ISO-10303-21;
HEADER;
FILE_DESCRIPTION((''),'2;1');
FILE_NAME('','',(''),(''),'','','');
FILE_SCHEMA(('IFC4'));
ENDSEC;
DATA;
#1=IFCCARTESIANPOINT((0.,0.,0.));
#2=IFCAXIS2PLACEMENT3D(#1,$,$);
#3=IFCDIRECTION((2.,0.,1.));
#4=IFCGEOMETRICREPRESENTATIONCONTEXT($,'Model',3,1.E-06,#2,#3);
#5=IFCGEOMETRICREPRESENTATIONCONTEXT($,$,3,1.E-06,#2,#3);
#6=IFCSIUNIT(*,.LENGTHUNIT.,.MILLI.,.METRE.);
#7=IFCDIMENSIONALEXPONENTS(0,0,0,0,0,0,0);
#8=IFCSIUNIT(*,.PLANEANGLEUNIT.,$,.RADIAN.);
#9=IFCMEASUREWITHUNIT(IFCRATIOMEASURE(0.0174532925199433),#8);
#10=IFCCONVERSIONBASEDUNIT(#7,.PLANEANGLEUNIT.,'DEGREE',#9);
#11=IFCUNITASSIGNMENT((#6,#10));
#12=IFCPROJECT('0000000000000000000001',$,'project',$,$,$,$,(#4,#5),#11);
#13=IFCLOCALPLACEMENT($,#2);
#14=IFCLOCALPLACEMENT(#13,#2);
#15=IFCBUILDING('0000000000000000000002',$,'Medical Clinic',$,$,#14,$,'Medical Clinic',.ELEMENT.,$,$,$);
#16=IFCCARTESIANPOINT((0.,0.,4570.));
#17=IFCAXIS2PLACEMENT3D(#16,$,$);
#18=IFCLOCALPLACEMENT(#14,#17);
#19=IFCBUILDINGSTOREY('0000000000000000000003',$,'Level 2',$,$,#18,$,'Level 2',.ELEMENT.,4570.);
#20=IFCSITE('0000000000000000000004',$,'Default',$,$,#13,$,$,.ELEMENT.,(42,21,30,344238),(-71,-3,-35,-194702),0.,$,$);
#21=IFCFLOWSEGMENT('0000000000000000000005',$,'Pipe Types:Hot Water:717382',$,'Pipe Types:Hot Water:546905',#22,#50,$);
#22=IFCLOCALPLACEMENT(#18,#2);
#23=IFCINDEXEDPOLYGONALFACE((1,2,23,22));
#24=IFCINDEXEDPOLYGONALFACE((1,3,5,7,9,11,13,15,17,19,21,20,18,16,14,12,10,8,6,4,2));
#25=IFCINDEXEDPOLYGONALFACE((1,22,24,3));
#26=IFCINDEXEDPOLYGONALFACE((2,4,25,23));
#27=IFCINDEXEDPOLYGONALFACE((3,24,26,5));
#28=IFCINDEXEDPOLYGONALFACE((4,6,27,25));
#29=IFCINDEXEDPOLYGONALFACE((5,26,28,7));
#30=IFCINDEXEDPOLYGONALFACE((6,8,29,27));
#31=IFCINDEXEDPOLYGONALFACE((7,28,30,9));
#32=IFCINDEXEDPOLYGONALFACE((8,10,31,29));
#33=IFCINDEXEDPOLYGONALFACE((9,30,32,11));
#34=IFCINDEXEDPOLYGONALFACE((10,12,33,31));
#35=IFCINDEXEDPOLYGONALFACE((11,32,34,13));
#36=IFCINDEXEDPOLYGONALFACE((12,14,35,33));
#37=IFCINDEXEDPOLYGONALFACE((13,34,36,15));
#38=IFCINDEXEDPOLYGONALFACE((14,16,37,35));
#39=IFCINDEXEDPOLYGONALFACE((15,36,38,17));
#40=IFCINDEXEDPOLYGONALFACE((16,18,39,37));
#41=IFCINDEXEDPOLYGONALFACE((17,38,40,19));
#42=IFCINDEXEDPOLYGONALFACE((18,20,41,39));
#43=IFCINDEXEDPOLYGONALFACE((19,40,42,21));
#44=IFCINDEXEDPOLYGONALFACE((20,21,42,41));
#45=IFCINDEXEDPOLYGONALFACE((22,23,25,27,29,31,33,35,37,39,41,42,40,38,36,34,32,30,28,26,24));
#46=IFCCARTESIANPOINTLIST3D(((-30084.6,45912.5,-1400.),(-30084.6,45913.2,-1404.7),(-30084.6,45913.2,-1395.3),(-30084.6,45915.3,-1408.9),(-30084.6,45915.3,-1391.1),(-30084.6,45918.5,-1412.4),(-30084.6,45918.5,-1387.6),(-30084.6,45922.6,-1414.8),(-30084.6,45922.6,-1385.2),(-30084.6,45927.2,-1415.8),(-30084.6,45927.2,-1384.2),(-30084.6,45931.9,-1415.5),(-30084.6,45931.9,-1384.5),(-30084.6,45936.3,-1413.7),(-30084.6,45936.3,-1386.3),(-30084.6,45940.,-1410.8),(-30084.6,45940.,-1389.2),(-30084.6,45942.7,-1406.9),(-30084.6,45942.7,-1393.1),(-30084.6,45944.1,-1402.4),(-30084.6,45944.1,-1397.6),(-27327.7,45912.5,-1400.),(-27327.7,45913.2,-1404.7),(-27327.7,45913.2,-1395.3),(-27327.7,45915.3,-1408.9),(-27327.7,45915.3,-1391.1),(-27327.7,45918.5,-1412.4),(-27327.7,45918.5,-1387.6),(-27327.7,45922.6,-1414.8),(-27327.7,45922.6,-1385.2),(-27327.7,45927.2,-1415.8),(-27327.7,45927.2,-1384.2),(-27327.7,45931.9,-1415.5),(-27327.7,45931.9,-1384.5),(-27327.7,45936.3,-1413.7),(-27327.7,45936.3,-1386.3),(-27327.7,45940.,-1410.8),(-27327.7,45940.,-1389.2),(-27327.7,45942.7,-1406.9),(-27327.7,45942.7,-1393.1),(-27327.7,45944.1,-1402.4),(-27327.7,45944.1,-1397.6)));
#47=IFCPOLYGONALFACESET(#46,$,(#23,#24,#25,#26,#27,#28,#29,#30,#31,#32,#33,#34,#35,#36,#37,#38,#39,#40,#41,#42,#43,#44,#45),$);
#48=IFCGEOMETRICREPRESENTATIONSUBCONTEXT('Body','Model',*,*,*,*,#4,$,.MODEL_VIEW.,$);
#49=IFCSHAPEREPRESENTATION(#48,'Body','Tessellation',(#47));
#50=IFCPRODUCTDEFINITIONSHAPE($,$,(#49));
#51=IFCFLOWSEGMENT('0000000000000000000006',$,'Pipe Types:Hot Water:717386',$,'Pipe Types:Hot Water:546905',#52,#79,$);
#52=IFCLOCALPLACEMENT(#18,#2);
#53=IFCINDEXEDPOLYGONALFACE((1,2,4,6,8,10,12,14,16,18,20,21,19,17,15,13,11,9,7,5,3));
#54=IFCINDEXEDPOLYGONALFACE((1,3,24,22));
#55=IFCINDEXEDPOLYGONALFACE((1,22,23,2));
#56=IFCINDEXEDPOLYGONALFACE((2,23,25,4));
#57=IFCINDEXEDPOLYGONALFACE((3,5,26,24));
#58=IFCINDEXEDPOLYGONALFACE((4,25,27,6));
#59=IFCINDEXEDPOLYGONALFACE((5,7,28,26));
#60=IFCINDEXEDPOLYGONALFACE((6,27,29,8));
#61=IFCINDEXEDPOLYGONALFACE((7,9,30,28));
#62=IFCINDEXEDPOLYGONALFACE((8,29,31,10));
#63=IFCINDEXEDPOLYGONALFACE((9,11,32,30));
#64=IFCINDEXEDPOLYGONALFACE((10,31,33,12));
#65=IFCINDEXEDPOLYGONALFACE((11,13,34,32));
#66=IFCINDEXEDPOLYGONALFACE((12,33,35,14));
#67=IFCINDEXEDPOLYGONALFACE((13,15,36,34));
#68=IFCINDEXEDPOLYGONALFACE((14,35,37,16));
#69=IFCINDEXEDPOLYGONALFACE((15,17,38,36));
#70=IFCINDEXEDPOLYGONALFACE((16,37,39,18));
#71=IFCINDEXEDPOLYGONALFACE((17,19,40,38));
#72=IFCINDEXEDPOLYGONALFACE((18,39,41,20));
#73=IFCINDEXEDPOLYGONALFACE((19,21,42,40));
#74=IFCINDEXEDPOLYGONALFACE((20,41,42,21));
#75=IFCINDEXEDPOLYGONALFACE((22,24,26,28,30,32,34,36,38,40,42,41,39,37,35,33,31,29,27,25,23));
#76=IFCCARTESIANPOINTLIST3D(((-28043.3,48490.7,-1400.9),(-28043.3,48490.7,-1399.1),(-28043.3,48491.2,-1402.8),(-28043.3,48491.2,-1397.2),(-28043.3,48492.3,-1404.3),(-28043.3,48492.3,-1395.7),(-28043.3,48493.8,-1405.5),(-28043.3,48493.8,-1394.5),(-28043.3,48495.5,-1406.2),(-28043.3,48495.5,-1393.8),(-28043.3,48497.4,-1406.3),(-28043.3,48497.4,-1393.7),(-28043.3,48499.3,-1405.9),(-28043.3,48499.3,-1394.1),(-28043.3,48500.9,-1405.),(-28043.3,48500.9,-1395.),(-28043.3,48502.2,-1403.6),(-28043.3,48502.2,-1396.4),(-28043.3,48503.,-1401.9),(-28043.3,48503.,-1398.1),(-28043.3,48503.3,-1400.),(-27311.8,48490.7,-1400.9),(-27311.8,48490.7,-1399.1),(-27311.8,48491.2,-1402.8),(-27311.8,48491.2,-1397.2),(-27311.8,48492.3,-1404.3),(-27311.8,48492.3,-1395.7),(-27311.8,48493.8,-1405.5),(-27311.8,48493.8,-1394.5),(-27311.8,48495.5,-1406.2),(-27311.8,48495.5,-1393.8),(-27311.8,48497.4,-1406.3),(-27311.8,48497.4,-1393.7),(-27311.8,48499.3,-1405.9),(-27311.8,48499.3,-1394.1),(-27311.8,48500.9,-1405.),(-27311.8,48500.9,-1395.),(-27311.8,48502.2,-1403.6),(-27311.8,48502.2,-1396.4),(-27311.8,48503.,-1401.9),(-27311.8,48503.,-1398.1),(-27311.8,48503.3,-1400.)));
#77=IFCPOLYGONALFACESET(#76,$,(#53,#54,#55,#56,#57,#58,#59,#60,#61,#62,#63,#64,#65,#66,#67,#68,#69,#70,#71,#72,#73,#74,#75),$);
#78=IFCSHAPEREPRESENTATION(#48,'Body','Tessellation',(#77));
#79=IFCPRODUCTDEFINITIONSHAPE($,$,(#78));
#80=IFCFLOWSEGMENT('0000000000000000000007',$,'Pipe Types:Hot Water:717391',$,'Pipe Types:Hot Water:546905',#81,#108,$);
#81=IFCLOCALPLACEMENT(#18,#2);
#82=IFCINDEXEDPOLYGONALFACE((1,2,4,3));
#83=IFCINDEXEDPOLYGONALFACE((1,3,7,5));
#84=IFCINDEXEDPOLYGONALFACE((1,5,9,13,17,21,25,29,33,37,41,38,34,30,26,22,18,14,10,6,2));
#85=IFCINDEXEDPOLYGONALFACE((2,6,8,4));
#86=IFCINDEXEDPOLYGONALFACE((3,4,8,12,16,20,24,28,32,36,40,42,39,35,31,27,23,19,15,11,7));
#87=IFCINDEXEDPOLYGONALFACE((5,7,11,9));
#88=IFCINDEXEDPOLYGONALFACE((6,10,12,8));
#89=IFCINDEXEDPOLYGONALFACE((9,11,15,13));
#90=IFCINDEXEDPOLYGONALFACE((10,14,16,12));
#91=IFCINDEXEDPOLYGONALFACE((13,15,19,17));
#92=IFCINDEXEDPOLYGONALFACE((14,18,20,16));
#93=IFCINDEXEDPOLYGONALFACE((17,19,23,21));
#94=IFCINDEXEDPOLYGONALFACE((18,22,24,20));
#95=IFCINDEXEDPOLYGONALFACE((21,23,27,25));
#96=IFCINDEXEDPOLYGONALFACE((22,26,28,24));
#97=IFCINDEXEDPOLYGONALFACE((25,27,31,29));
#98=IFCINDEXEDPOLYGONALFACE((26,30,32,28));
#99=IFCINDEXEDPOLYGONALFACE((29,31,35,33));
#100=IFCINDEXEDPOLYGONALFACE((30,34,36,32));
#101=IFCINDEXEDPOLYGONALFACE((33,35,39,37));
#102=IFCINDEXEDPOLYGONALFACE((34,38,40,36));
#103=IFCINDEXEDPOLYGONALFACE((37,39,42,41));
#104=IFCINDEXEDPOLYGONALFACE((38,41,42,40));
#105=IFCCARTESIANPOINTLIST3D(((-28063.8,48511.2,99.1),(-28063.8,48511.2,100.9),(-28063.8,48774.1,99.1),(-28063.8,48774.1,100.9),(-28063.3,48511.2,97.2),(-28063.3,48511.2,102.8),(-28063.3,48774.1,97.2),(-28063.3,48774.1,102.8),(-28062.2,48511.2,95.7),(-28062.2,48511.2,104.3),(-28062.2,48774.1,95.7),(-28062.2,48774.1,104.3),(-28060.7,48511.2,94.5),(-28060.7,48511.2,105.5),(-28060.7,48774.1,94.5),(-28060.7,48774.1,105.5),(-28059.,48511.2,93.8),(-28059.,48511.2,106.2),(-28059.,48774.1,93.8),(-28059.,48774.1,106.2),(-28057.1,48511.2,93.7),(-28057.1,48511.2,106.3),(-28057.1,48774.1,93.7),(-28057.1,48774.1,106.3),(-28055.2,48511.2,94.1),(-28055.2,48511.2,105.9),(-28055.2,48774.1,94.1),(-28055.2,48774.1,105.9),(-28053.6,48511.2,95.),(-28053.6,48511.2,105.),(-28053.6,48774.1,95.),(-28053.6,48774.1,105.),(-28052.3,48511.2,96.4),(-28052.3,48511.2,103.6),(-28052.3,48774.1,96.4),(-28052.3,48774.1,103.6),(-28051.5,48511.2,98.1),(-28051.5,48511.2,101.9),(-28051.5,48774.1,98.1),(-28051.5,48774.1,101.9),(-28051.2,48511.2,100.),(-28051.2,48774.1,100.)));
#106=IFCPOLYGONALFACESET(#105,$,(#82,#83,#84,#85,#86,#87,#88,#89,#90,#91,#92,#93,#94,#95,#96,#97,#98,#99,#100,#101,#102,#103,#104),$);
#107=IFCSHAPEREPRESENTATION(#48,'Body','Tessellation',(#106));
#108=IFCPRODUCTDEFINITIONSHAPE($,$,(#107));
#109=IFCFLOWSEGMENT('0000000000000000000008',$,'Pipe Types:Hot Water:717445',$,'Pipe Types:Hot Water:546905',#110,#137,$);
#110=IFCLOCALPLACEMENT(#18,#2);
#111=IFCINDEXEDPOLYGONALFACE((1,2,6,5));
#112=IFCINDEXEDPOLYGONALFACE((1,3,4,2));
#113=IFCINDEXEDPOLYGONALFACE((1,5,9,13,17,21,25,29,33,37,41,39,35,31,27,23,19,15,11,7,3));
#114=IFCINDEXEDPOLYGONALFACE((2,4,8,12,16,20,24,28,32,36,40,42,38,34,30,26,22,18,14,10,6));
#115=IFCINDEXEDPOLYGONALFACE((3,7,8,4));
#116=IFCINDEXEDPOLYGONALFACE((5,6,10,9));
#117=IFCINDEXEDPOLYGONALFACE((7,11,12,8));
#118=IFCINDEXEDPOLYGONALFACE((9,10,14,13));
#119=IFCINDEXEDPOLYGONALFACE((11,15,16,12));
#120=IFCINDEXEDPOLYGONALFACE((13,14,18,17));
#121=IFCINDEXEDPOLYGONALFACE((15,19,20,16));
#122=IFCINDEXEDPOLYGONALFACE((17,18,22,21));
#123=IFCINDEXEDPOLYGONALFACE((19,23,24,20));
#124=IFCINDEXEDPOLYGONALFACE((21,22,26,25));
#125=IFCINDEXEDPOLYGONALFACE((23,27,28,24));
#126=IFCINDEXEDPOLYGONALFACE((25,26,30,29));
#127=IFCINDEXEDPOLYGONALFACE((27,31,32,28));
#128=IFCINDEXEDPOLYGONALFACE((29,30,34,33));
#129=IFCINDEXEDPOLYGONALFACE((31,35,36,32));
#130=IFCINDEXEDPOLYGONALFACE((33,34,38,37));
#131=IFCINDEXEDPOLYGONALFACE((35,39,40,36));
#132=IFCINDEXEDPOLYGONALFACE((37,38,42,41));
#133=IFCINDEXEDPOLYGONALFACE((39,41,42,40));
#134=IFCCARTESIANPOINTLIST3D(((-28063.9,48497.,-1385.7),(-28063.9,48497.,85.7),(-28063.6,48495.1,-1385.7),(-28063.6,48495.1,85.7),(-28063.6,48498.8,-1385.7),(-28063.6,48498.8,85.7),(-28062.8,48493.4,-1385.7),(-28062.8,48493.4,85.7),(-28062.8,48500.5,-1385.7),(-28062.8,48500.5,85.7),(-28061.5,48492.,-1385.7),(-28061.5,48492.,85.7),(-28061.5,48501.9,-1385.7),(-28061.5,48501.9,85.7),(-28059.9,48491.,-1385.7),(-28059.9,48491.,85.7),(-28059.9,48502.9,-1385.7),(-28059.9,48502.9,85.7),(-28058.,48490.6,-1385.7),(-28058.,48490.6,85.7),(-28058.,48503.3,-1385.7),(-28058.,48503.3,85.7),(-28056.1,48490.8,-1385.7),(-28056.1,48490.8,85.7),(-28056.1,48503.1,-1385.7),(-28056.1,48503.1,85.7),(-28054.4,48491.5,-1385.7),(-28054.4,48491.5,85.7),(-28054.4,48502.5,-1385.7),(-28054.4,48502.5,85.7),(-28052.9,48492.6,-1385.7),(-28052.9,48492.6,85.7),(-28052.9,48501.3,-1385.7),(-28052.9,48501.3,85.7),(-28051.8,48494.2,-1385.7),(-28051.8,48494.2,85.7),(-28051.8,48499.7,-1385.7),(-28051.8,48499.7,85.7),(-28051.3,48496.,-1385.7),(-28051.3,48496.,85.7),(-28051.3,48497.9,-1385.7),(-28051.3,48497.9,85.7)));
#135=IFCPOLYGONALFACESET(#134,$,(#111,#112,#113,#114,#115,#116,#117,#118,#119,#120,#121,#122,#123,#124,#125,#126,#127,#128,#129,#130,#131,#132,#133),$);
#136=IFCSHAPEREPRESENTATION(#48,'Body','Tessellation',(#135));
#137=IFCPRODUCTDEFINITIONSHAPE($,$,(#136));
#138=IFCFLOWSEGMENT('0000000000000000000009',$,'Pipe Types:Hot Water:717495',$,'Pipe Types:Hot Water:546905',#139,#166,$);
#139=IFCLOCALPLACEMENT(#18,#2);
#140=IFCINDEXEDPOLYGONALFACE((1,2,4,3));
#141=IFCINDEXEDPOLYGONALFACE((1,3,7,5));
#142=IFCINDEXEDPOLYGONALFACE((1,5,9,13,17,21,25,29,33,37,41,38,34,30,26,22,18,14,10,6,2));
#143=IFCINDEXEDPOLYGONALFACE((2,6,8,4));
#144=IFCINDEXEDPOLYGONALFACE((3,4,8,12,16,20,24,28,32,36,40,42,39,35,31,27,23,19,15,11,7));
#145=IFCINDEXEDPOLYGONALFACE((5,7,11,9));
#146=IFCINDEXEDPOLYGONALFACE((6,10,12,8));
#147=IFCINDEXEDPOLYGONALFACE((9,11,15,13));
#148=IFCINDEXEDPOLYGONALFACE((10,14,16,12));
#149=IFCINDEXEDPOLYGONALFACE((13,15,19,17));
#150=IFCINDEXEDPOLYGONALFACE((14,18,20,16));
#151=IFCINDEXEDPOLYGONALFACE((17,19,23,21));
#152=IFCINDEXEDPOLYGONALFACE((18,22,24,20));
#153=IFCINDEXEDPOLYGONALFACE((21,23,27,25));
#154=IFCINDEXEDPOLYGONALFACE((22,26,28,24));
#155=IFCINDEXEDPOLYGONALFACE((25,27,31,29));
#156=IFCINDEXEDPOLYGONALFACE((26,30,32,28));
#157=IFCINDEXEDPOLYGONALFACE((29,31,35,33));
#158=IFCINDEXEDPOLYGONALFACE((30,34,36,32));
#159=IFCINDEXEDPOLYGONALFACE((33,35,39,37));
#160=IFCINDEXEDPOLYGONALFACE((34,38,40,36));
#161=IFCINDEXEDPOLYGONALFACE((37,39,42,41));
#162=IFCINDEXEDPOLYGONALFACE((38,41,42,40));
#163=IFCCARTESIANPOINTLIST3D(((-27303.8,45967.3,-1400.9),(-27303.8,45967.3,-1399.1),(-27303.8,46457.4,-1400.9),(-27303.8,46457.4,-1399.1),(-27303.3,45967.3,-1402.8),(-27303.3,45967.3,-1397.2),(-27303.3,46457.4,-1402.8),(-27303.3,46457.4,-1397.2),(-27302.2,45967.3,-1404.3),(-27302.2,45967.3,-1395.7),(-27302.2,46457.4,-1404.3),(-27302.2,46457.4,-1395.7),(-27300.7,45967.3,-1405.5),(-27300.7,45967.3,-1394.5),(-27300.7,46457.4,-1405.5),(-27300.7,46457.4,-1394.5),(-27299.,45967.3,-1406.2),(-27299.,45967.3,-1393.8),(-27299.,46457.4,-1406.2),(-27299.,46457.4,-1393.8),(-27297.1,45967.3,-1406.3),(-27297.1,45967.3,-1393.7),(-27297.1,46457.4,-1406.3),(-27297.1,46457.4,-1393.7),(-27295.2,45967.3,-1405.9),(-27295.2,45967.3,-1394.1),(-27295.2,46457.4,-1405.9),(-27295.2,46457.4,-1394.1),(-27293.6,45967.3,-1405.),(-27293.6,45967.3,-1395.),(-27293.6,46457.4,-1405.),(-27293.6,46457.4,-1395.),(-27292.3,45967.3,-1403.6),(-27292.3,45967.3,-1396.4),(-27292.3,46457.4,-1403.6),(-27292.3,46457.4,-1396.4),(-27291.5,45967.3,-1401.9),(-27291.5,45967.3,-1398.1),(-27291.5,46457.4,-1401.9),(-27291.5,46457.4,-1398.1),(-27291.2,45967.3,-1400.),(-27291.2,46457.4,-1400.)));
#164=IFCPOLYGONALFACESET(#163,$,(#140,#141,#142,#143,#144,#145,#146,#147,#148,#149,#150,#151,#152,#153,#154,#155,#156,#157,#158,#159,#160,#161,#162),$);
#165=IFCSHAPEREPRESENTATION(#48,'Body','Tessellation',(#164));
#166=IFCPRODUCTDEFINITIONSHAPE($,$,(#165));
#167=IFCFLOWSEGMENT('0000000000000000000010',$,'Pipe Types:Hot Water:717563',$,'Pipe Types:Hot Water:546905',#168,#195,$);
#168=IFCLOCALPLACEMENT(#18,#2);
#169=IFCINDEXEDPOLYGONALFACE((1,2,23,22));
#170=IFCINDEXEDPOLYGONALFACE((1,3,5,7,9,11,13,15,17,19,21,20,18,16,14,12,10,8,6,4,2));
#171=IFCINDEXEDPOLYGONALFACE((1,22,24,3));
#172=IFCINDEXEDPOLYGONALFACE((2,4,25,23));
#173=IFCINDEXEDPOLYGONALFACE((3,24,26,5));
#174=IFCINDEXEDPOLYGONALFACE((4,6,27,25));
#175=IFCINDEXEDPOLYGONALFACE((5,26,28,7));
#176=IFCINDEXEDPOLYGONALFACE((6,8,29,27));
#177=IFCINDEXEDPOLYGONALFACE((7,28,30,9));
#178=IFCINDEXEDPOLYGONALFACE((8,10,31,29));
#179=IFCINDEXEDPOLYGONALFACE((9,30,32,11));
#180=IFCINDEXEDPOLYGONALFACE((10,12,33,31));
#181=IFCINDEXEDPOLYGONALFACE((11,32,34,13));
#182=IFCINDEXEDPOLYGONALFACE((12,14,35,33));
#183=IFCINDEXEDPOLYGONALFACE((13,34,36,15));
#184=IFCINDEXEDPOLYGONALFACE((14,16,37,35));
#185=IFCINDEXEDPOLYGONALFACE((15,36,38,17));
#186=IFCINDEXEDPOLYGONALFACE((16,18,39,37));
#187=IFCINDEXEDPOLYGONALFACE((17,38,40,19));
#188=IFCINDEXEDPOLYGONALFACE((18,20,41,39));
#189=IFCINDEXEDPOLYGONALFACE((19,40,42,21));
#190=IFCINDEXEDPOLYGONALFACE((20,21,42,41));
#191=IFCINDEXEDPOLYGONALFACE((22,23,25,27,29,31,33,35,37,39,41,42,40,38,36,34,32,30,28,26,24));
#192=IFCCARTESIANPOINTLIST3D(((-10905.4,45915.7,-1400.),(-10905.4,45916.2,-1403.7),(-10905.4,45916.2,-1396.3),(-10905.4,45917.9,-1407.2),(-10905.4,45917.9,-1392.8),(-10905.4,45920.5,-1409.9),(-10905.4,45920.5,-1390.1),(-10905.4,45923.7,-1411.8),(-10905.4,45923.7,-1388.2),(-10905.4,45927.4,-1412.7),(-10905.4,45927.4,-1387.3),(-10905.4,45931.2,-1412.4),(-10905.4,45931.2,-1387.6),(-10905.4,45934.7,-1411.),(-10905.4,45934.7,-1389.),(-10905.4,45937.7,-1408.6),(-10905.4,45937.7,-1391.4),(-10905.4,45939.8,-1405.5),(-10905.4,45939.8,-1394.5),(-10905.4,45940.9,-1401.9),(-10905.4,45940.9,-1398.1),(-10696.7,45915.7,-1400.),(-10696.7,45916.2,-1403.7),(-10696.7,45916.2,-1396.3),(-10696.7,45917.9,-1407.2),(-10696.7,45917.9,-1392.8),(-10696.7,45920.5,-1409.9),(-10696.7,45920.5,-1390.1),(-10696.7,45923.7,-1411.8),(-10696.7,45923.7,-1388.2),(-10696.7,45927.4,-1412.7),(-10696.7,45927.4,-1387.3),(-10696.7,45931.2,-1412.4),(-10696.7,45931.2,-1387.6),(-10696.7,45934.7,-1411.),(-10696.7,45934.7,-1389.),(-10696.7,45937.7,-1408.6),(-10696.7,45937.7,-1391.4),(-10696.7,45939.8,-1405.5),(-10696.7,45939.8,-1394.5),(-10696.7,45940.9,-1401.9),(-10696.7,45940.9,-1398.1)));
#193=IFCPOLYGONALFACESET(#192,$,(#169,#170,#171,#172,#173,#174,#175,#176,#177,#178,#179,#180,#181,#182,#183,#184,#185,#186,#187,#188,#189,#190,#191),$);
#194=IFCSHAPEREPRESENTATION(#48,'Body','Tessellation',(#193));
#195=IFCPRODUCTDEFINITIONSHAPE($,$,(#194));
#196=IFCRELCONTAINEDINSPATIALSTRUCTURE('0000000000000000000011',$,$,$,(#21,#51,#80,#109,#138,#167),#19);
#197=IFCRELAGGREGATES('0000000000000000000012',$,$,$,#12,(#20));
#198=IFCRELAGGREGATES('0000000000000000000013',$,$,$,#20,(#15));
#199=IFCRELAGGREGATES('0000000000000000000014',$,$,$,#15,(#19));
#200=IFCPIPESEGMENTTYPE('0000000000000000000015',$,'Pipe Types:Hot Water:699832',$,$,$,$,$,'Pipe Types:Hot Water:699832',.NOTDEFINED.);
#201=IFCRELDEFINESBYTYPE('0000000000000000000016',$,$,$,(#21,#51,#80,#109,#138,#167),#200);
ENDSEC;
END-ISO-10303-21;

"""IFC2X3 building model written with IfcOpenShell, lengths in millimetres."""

from ifc_helpers import new_model, entity, si_unit, converted_unit, direction, frame, frame_2d, origin, origin_2d_with_axis, place, context, subcontext, project, spatial, circle, extrude, type_object, element, save


model = new_model("IFC2X3")

# Units and contexts
model_context = context("Model", 3, precision=1e-06, world=origin(), true_north=direction((2.0, 0.0, 1.0)))
context_of_model = context(None, 3, precision=1e-06, world=origin(), true_north=direction((2.0, 0.0, 1.0)))
body_context = subcontext(model_context, "Body", "Model", "MODEL_VIEW")
ifc_project = project(units=[si_unit("LENGTHUNIT", "METRE", prefix="MILLI"), converted_unit("PLANEANGLEUNIT", "DEGREE", entity("IfcRatioMeasure", 0.0174532925199433), si_unit("PLANEANGLEUNIT", "RADIAN"), dimensions=[0, 0, 0, 0, 0, 0, 0])], contexts=[model_context, context_of_model])

# Site, building, storey
site_placement = place(None, origin())
site = spatial("IfcSite", under=ifc_project, at=site_placement, Name="Default", CompositionType="ELEMENT", RefLatitude=(42, 21, 30, 344238), RefLongitude=(-71, -3, -35, -194702), RefElevation=0.0)
building_placement = place(site_placement, origin())
building = spatial("IfcBuilding", under=site, at=building_placement, Name="Medical Clinic", LongName="Medical Clinic", CompositionType="ELEMENT")
storey_placement = place(building_placement, frame((0.0, 0.0, 4570.0)))
storey = spatial("IfcBuildingStorey", under=building, at=storey_placement, Name="Level 2", LongName="Level 2", CompositionType="ELEMENT", Elevation=4570.0)

# Flow segments
pipe_segment_type = type_object("IfcPipeSegmentType", Name="Pipe Types:Hot Water:699832", ElementType="Pipe Types:Hot Water:699832", PredefinedType="NOTDEFINED")
flow_segment_1_placement = place(storey_placement, origin())
element("IfcFlowSegment", 1, at=flow_segment_1_placement, inside=storey, type_object=pipe_segment_type, Name="Pipe Types:Hot Water:717382", ObjectType="Pipe Types:Hot Water:546905", context=body_context, shape_type="SweptSolid", body=[
    extrude(circle(Radius=15.9, at=origin_2d_with_axis()), frame((-30084.6, 45928.4, -1400.0), z_axis=(1.0, 0.0, 0.0), x_axis=(0.0, -1.0, 0.0)), (0.0, 0.0, 1.0), 2756.8),
])
flow_segment_2_placement = place(storey_placement, origin())
element("IfcFlowSegment", 2, at=flow_segment_2_placement, inside=storey, type_object=pipe_segment_type, Name="Pipe Types:Hot Water:717386", ObjectType="Pipe Types:Hot Water:546905", context=body_context, shape_type="SweptSolid", body=[
    extrude(circle(Radius=6.3, at=frame_2d((0.0, 0.0), x_axis=(1.0, 0.0))), frame((-28043.3, 48497.0, -1400.0), z_axis=(1.0, 0.0, 0.0), x_axis=(0.0, 1.0, 0.0)), (0.0, 0.0, 1.0), 731.4),
])
flow_segment_3_placement = place(storey_placement, origin())
element("IfcFlowSegment", 3, at=flow_segment_3_placement, inside=storey, type_object=pipe_segment_type, Name="Pipe Types:Hot Water:717391", ObjectType="Pipe Types:Hot Water:546905", context=body_context, shape_type="SweptSolid", body=[
    extrude(circle(Radius=6.3, at=origin_2d_with_axis()), frame((-28057.6, 48511.2, 100.0), z_axis=(0.0, 1.0, 0.0), x_axis=(1.0, 0.0, 0.0)), (0.0, 0.0, 1.0), 262.9),
])
flow_segment_4_placement = place(storey_placement, origin())
element("IfcFlowSegment", 4, at=flow_segment_4_placement, inside=storey, type_object=pipe_segment_type, Name="Pipe Types:Hot Water:717445", ObjectType="Pipe Types:Hot Water:546905", context=body_context, shape_type="SweptSolid", body=[
    extrude(circle(Radius=6.3, at=origin_2d_with_axis()), frame((-28057.6, 48497.0, -1385.7), z_axis=(0.0, 0.0, 1.0), x_axis=(-1.0, 0.0, 0.0)), (0.0, 0.0, 1.0), 1471.4),
])
flow_segment_5_placement = place(storey_placement, origin())
element("IfcFlowSegment", 5, at=flow_segment_5_placement, inside=storey, type_object=pipe_segment_type, Name="Pipe Types:Hot Water:717495", ObjectType="Pipe Types:Hot Water:546905", context=body_context, shape_type="SweptSolid", body=[
    extrude(circle(Radius=6.3, at=origin_2d_with_axis()), frame((-27297.6, 45967.3, -1400.0), z_axis=(0.0, 1.0, 0.0), x_axis=(1.0, 0.0, 0.0)), (0.0, 0.0, 1.0), 490.1),
])
flow_segment_6_placement = place(storey_placement, origin())
element("IfcFlowSegment", 6, at=flow_segment_6_placement, inside=storey, type_object=pipe_segment_type, Name="Pipe Types:Hot Water:717563", ObjectType="Pipe Types:Hot Water:546905", context=body_context, shape_type="SweptSolid", body=[
    extrude(circle(Radius=12.7, at=origin_2d_with_axis()), frame((-10905.4, 45928.4, -1400.0), z_axis=(1.0, 0.0, 0.0), x_axis=(0.0, -1.0, 0.0)), (0.0, 0.0, 1.0), 208.8),
])

save(model, "model.ifc")
